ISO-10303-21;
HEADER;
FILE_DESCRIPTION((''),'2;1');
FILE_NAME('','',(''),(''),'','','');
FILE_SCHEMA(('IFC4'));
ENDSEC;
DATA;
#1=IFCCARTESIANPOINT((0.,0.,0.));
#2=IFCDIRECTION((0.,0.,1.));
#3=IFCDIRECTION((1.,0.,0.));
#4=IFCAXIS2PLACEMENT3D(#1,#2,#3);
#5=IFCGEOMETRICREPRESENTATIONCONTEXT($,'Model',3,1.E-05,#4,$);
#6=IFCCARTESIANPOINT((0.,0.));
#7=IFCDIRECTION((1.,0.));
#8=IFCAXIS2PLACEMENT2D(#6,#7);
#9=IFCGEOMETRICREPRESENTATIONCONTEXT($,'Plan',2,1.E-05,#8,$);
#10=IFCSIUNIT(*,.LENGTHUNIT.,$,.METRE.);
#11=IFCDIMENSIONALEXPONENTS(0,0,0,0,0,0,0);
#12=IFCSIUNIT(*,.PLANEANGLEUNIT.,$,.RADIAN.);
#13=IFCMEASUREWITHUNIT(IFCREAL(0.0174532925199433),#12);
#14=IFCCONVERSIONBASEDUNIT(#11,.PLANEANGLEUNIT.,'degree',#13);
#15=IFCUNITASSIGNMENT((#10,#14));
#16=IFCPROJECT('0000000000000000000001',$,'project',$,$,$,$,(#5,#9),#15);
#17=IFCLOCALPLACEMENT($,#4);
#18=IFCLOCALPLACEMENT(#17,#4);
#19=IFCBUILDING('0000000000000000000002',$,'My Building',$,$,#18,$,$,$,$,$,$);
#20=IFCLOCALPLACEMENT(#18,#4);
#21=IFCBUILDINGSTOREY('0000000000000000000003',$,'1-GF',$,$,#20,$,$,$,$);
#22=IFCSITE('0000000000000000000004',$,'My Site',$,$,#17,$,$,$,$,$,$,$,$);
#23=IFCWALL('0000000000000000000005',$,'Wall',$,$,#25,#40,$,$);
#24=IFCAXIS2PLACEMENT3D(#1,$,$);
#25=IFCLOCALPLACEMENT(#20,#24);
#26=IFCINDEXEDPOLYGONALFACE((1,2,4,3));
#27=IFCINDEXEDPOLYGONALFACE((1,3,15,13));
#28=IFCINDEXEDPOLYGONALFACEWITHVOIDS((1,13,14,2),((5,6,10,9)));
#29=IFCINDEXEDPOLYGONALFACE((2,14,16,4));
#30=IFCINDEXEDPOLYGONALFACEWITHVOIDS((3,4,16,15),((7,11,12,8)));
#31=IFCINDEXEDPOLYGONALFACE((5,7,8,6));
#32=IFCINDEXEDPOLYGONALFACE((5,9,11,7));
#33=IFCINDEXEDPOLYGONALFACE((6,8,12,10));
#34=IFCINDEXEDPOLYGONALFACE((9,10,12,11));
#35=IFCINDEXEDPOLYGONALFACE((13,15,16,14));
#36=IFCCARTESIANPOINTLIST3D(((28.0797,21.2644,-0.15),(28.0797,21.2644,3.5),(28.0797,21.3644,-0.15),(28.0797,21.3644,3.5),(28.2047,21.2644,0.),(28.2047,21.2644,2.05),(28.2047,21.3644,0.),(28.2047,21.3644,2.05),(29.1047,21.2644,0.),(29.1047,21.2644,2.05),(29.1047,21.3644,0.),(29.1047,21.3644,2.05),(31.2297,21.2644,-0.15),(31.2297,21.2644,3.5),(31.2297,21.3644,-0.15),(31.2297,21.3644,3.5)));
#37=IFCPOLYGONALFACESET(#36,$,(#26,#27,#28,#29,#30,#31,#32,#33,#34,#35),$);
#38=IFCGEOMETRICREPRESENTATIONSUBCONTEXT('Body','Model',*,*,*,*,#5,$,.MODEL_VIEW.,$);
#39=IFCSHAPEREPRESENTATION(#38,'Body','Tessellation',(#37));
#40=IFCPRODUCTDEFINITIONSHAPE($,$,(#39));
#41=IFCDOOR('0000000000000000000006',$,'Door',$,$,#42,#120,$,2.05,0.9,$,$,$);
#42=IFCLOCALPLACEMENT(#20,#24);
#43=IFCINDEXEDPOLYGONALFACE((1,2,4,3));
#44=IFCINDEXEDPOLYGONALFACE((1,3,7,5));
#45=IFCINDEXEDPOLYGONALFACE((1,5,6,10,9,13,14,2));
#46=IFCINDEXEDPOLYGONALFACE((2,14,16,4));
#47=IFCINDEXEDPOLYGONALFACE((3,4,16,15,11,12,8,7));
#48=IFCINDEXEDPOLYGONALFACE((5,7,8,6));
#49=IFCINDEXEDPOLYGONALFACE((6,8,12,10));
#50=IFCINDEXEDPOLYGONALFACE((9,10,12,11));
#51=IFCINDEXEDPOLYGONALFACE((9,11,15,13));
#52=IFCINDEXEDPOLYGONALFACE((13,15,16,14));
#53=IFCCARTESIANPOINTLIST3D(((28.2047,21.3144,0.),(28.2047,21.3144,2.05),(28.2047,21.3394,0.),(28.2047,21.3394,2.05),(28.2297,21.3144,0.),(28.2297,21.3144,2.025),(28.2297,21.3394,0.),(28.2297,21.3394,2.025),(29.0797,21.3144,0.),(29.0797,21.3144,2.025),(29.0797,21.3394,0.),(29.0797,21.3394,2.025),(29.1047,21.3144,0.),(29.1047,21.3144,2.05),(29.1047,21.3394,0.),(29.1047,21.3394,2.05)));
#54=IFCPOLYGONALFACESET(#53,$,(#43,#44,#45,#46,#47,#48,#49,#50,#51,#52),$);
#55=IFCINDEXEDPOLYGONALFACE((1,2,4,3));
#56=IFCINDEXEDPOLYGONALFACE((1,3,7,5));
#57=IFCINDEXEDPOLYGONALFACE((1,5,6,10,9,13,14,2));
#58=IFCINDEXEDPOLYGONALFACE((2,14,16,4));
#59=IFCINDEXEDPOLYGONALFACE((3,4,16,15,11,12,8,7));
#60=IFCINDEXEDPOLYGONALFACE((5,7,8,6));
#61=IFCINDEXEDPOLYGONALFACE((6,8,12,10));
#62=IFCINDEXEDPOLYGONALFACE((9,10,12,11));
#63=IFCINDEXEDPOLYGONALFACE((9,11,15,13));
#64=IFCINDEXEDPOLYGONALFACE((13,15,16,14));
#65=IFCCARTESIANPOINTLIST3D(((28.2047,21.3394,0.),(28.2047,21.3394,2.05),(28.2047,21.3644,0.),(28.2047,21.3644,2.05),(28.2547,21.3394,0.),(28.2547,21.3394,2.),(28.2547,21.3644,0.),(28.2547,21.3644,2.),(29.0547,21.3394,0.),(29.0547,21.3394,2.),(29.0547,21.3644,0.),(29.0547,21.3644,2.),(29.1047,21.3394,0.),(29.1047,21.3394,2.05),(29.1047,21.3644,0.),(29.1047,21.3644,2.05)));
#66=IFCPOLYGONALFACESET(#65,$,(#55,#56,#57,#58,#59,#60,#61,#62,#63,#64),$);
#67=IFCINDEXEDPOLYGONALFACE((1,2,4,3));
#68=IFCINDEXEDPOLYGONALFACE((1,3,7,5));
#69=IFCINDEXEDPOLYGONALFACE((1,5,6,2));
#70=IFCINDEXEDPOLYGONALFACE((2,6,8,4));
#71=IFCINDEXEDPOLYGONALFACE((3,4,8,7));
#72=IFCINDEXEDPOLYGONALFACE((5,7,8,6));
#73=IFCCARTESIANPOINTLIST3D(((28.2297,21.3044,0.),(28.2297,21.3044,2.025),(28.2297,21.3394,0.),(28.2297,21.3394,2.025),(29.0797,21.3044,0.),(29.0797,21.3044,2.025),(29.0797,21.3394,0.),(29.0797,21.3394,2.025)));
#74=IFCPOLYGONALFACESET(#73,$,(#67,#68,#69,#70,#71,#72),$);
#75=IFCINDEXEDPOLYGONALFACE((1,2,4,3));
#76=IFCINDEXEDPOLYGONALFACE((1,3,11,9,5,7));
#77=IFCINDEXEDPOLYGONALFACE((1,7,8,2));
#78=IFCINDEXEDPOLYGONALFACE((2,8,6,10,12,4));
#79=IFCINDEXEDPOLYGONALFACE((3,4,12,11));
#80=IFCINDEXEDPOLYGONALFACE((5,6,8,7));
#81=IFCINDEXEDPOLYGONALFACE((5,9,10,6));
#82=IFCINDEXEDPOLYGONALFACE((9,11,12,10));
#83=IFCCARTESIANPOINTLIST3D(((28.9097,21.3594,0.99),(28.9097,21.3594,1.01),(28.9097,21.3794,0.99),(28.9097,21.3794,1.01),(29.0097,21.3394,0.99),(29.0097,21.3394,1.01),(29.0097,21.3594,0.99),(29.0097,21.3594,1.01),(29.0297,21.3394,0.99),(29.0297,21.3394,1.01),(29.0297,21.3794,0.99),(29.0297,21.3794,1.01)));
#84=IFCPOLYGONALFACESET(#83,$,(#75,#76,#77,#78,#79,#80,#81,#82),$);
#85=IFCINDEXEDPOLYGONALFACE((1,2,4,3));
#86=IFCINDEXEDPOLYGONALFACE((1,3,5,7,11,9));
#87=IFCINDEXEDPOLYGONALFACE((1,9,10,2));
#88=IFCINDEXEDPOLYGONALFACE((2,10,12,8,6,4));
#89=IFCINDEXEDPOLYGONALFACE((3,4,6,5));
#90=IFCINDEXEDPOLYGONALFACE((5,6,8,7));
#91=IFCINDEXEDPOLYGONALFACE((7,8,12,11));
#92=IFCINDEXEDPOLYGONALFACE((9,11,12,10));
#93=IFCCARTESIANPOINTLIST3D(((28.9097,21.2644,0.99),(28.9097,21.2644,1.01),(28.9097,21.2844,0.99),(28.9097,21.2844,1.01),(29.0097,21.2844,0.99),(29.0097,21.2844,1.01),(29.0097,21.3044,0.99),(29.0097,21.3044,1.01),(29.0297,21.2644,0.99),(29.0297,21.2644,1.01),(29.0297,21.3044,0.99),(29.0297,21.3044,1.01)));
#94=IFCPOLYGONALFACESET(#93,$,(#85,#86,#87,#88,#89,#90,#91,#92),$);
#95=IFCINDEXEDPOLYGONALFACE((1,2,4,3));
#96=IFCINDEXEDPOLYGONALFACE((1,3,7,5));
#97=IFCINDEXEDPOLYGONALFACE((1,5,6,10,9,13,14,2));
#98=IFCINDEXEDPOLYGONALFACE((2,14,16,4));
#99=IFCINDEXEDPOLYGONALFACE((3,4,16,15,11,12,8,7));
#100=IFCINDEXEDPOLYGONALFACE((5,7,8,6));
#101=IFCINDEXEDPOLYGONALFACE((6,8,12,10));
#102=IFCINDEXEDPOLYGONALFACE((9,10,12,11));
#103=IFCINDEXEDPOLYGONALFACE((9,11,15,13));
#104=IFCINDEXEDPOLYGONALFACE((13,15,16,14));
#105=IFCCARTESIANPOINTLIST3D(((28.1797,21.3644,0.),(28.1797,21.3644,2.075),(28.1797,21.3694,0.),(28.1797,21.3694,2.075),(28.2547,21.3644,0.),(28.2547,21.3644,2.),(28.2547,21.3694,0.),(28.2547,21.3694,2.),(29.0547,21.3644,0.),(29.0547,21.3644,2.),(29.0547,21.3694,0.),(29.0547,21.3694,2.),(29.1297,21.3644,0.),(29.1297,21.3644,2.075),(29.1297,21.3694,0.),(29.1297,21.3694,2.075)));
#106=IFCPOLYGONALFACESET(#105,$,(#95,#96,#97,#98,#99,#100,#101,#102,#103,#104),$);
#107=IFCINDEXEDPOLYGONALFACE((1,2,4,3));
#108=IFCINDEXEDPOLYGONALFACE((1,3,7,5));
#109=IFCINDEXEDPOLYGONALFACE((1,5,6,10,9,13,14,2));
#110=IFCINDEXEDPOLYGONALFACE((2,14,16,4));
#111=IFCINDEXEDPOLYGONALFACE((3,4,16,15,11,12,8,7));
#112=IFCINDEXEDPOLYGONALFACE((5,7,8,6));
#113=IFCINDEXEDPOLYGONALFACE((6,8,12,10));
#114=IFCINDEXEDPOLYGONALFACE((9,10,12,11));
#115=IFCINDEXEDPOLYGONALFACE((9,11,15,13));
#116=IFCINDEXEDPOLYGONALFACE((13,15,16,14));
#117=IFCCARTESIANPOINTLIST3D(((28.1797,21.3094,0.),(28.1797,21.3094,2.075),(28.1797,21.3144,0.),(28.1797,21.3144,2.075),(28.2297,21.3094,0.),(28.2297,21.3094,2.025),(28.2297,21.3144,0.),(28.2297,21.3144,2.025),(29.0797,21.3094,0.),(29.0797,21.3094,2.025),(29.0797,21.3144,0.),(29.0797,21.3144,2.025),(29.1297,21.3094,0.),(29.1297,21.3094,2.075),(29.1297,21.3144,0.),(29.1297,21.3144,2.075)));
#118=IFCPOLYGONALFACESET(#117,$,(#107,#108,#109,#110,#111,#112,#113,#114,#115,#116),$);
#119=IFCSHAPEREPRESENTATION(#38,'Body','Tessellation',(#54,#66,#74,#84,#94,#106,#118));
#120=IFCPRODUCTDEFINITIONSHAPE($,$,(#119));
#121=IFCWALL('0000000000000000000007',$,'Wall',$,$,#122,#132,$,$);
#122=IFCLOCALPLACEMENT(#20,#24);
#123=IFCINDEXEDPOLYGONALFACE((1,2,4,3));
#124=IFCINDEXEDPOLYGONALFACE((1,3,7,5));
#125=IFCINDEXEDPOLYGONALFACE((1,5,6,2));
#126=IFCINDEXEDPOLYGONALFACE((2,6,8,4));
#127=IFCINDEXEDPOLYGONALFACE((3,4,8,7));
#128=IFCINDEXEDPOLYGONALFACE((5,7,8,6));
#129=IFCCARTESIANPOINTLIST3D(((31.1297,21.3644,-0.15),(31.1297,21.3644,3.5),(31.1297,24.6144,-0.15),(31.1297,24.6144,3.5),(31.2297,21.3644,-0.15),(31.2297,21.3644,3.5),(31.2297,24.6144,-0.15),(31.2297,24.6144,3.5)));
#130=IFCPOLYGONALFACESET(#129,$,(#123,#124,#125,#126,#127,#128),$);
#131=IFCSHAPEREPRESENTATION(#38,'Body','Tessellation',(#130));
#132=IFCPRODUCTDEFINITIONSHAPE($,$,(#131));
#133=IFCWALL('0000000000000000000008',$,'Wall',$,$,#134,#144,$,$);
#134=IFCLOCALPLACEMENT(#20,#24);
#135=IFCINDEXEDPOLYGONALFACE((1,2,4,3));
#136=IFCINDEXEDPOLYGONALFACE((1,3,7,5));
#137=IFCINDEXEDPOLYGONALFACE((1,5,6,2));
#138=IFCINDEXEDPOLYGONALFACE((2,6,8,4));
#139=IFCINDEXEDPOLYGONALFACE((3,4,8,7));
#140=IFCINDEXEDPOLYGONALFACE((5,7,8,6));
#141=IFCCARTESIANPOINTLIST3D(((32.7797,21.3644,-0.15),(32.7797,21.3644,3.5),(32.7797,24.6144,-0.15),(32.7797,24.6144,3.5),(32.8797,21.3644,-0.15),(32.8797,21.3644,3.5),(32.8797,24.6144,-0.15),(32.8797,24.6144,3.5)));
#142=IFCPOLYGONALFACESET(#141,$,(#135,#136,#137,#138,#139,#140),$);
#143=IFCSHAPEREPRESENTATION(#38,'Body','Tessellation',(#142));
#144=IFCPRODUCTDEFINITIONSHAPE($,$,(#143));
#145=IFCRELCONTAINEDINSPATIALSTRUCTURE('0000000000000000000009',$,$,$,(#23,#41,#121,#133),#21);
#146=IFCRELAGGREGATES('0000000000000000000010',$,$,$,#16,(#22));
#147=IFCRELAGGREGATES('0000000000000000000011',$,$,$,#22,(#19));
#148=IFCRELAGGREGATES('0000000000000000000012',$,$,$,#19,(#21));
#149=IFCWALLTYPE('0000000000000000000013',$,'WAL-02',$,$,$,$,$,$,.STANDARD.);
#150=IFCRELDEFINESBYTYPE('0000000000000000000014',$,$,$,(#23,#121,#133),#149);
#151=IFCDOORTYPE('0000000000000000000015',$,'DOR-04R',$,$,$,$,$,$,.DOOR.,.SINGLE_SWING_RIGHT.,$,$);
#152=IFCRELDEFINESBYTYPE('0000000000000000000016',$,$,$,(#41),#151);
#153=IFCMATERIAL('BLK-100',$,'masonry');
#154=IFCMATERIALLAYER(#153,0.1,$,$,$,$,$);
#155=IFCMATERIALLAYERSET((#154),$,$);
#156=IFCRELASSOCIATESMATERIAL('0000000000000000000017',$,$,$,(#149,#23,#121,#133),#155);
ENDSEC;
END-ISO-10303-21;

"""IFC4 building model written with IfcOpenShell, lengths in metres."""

from ifc_helpers import new_model, entity, si_unit, converted_unit, frame, origin_with_axes, origin_2d_with_axis, place, context, subcontext, project, spatial, line, indexed_curve, outline, extrude, shape, source, transform, mapped, material, layer, layer_set, layer_usage, type_object, type_shapes, element, fill, save


model = new_model("IFC4")

# Units and contexts
model_context = context("Model", 3, precision=1e-05, world=origin_with_axes())
plan_context = context("Plan", 2, precision=1e-05, world=origin_2d_with_axis())
body_context_1 = subcontext(model_context, "Body", "Model", "MODEL_VIEW")
body_context_2 = subcontext(plan_context, "Body", "Plan", "PLAN_VIEW")
ifc_project = project(units=[si_unit("LENGTHUNIT", "METRE"), converted_unit("PLANEANGLEUNIT", "degree", entity("IfcReal", 0.0174532925199433), si_unit("PLANEANGLEUNIT", "RADIAN"), dimensions=[0, 0, 0, 0, 0, 0, 0])], contexts=[model_context, plan_context])

# Site, building, storey
site_placement = place(None, origin_with_axes())
site = spatial("IfcSite", under=ifc_project, at=site_placement, Name="My Site")
building_placement = place(site_placement, origin_with_axes())
building = spatial("IfcBuilding", under=site, at=building_placement, Name="My Building")
storey_placement = place(building_placement, origin_with_axes())
storey = spatial("IfcBuildingStorey", under=building, at=storey_placement, Name="1-GF")

# Wall, opening, door
ifc_material_1 = material(Name="BLK-100", Category="masonry")
ifc_layer_1 = layer(ifc_material_1, 0.1)
ifc_layer_set_1 = layer_set([ifc_layer_1])
wall_type = type_object("IfcWallType", Name="WAL-02", PredefinedType="STANDARD", material=ifc_layer_set_1)
shared_shape_1 = source(origin_with_axes(), body_context_1, "Body", "SweptSolid", [
    extrude(outline(indexed_curve([(0.0, 0.0), (0.9, 0.0), (0.9, 2.05), (0.0, 2.05)], segments=[line(1, 2, 3, 4, 1)])), frame((0.0, -0.6, 0.0), z_axis=(0.0, -1.0, 0.0), x_axis=(1.0, 0.0, 0.0)), (0.0, 0.0, -1.0), 1.2),
])
door_type_1 = type_object("IfcDoorType", Name="DOR-04R", OperationType="SINGLE_SWING_RIGHT", PredefinedType="DOOR")
shared_shape_2 = source(origin_with_axes(), body_context_1, "Body", "SweptSolid", [
    extrude(outline(indexed_curve([(0.0, 0.0), (0.0, 2.05), (0.9, 2.05), (0.9, 0.0), (0.875, 0.0), (0.875, 2.025), (0.025, 2.025), (0.025, 0.0)], segments=[line(1, 2, 3, 4, 5, 6, 7, 8, 1)])), frame((0.0, 0.025, 0.0), z_axis=(0.0, -1.0, 0.0), x_axis=(1.0, 0.0, 0.0)), (0.0, 0.0, -1.0), 0.025),
    extrude(outline(indexed_curve([(0.0, 0.0), (0.0, 2.05), (0.9, 2.05), (0.9, 0.0), (0.85, 0.0), (0.85, 2.0), (0.05, 2.0), (0.05, 0.0)], segments=[line(1, 2, 3, 4, 5, 6, 7, 8, 1)])), frame((0.0, 0.0, 0.0), z_axis=(0.0, -1.0, 0.0), x_axis=(1.0, 0.0, 0.0)), (0.0, 0.0, -1.0), 0.025),
    extrude(outline(indexed_curve([(0.0, 0.0), (0.85, 0.0), (0.85, 0.035), (0.0, 0.035)], segments=[line(1, 2, 3, 4, 1)])), frame((0.025, 0.025, 0.0), z_axis=(0.0, 0.0, 1.0), x_axis=(1.0, 0.0, 0.0)), (0.0, 0.0, 1.0), 2.025),
    extrude(outline(indexed_curve([(0.0, 0.0), (0.0, -0.04), (0.12, -0.04), (0.12, -0.02), (0.02, -0.02), (0.02, 0.0)], segments=[line(1, 2, 3, 4, 5, 6, 1)])), frame((0.075, 0.025, 0.99), z_axis=(0.0, 0.0, 1.0), x_axis=(1.0, 0.0, 0.0)), (0.0, 0.0, 1.0), 0.02),
    extrude(outline(indexed_curve([(0.0, 0.0), (0.0, 0.04), (0.12, 0.04), (0.12, 0.02), (0.02, 0.02), (0.02, 0.0)], segments=[line(1, 2, 3, 4, 5, 6, 1)])), frame((0.075, 0.06, 0.99), z_axis=(0.0, 0.0, 1.0), x_axis=(1.0, 0.0, 0.0)), (0.0, 0.0, 1.0), 0.02),
    extrude(outline(indexed_curve([(0.0, 0.0), (0.0, 2.075), (0.95, 2.075), (0.95, 0.0), (0.875, 0.0), (0.875, 2.0), (0.075, 2.0), (0.075, 0.0)], segments=[line(1, 2, 3, 4, 5, 6, 7, 8, 1)])), frame((-0.025, -0.005, 0.0), z_axis=(0.0, -1.0, 0.0), x_axis=(1.0, 0.0, 0.0)), (0.0, 0.0, -1.0), 0.005),
    extrude(outline(indexed_curve([(0.0, 0.0), (0.0, 2.075), (0.95, 2.075), (0.95, 0.0), (0.9, 0.0), (0.9, 2.025), (0.05, 2.025), (0.05, 0.0)], segments=[line(1, 2, 3, 4, 5, 6, 7, 8, 1)])), frame((-0.025, 0.05, 0.0), z_axis=(0.0, -1.0, 0.0), x_axis=(1.0, 0.0, 0.0)), (0.0, 0.0, -1.0), 0.005),
])
shared_shape_3 = source(origin_with_axes(), body_context_2, "Body", "Curve2D", [
    entity("IfcIndexedPolyCurve", entity("IfcCartesianPointList2D", [[0.0, 0.0], [0.0, 0.05], [0.025, 0.05], [0.025, 0.025], [0.05, 0.025], [0.05, 0.0]]), [entity("IfcLineIndex", [1, 2, 3, 4, 5, 6, 1])]),
    entity("IfcIndexedPolyCurve", entity("IfcCartesianPointList2D", [[0.9, 0.0], [0.9, 0.05], [0.875, 0.05], [0.875, 0.025], [0.85, 0.025], [0.85, 0.0]]), [entity("IfcLineIndex", [1, 2, 3, 4, 5, 6, 1])]),
    entity("IfcTrimmedCurve", entity("IfcEllipse", entity("IfcAxis2Placement2D", entity("IfcCartesianPoint", [0.84, 0.05]), entity("IfcDirection", [1.0, 0.0])), 0.815, 0.85), [entity("IfcCartesianPoint", [0.84, 0.9])], [entity("IfcCartesianPoint", [0.025, 0.05])], True, "CARTESIAN"),
    entity("IfcIndexedPolyCurve", entity("IfcCartesianPointList2D", [[0.875, 0.05], [0.84, 0.05], [0.84, 0.9], [0.875, 0.9]]), [entity("IfcLineIndex", [1, 2, 3, 4, 1])]),
])
type_shapes(door_type_1, [shared_shape_2, shared_shape_3])
ifc_layer_usage_1 = layer_usage(ifc_layer_set_1, "AXIS2", "POSITIVE", 0.0)
wall_1_placement = place(storey_placement, frame((31.2297, 21.3644, -0.15), z_axis=(0.0, 0.0, 1.0), x_axis=(-1.0, 0.000001, 0.0)))
wall_1 = element("IfcWall", 1, at=wall_1_placement, inside=storey, type_object=wall_type, material=ifc_layer_usage_1, Name="Wall", context=body_context_1, shape_type="SweptSolid", body=[
    extrude(outline(indexed_curve([(0.0, 0.0), (0.0, 0.1), (3.15, 0.1), (3.15, 0.0), (0.0, 0.0)], self_intersect=False)), origin_with_axes(), (0.0, 0.0, 1.0), 3.65),
])
opening_1_placement = place(wall_1_placement, frame((2.125, 0.0, 0.15), z_axis=(0.0, 0.0, 1.0), x_axis=(1.0, 0.0, 0.0)))
opening_1 = element("IfcOpeningElement", 2, at=opening_1_placement, cuts=wall_1, PredefinedType="OPENING", context=body_context_1, shape_type="MappedRepresentation", body=[
    mapped(shared_shape_1, transform((0.0, 0.0, 0.0), x_axis=(1.0, 0.0, 0.0), y_axis=(0.0, 1.0, 0.0), z_axis=(0.0, 0.0, 1.0), scale=1.0)),
])
door_1_placement = place(opening_1_placement, origin_with_axes())
door_1 = element("IfcDoor", 3, at=door_1_placement, inside=storey, type_object=door_type_1, Name="Door", OverallHeight=2.05, OverallWidth=0.9, shapes=[
    shape(body_context_1, "Body", "MappedRepresentation", [mapped(shared_shape_2, transform((0.0, 0.0, 0.0), x_axis=(1.0, 0.0, 0.0), y_axis=(0.0, 1.0, 0.0), z_axis=(0.0, 0.0, 1.0), scale=1.0))]),
    shape(body_context_2, "Body", "MappedRepresentation", [mapped(shared_shape_3, transform((0.0, 0.0, 0.0), x_axis=(1.0, 0.0, 0.0), y_axis=(0.0, 1.0, 0.0), z_axis=(0.0, 0.0, 1.0), scale=1.0))]),
])
fill(opening_1, door_1)

# Walls
ifc_layer_usage_2 = layer_usage(ifc_layer_set_1, "AXIS2", "POSITIVE", 0.0)
wall_2_placement = place(storey_placement, frame((31.2297, 21.3644, -0.15), z_axis=(0.0, 0.0, 1.0), x_axis=(0.0, 1.0, 0.0)))
element("IfcWall", 4, at=wall_2_placement, inside=storey, type_object=wall_type, material=ifc_layer_usage_2, Name="Wall", context=body_context_1, shape_type="SweptSolid", body=[
    extrude(outline(indexed_curve([(0.0, 0.0), (0.0, 0.1), (3.25, 0.1), (3.25, 0.0), (0.0, 0.0)], self_intersect=False)), origin_with_axes(), (0.0, 0.0, 1.0), 3.65),
])
ifc_layer_usage_3 = layer_usage(ifc_layer_set_1, "AXIS2", "POSITIVE", 0.0)
wall_3_placement = place(storey_placement, frame((32.8797, 21.3644, -0.15), z_axis=(0.0, 0.0, 1.0), x_axis=(0.0, 1.0, 0.0)))
element("IfcWall", 5, at=wall_3_placement, inside=storey, type_object=wall_type, material=ifc_layer_usage_3, Name="Wall", context=body_context_1, shape_type="SweptSolid", body=[
    extrude(outline(indexed_curve([(0.0, 0.0), (0.0, 0.1), (3.25, 0.1), (3.25, 0.0), (0.0, 0.0)], self_intersect=False)), origin_with_axes(), (0.0, 0.0, 1.0), 3.65),
])

save(model, "model.ifc")
